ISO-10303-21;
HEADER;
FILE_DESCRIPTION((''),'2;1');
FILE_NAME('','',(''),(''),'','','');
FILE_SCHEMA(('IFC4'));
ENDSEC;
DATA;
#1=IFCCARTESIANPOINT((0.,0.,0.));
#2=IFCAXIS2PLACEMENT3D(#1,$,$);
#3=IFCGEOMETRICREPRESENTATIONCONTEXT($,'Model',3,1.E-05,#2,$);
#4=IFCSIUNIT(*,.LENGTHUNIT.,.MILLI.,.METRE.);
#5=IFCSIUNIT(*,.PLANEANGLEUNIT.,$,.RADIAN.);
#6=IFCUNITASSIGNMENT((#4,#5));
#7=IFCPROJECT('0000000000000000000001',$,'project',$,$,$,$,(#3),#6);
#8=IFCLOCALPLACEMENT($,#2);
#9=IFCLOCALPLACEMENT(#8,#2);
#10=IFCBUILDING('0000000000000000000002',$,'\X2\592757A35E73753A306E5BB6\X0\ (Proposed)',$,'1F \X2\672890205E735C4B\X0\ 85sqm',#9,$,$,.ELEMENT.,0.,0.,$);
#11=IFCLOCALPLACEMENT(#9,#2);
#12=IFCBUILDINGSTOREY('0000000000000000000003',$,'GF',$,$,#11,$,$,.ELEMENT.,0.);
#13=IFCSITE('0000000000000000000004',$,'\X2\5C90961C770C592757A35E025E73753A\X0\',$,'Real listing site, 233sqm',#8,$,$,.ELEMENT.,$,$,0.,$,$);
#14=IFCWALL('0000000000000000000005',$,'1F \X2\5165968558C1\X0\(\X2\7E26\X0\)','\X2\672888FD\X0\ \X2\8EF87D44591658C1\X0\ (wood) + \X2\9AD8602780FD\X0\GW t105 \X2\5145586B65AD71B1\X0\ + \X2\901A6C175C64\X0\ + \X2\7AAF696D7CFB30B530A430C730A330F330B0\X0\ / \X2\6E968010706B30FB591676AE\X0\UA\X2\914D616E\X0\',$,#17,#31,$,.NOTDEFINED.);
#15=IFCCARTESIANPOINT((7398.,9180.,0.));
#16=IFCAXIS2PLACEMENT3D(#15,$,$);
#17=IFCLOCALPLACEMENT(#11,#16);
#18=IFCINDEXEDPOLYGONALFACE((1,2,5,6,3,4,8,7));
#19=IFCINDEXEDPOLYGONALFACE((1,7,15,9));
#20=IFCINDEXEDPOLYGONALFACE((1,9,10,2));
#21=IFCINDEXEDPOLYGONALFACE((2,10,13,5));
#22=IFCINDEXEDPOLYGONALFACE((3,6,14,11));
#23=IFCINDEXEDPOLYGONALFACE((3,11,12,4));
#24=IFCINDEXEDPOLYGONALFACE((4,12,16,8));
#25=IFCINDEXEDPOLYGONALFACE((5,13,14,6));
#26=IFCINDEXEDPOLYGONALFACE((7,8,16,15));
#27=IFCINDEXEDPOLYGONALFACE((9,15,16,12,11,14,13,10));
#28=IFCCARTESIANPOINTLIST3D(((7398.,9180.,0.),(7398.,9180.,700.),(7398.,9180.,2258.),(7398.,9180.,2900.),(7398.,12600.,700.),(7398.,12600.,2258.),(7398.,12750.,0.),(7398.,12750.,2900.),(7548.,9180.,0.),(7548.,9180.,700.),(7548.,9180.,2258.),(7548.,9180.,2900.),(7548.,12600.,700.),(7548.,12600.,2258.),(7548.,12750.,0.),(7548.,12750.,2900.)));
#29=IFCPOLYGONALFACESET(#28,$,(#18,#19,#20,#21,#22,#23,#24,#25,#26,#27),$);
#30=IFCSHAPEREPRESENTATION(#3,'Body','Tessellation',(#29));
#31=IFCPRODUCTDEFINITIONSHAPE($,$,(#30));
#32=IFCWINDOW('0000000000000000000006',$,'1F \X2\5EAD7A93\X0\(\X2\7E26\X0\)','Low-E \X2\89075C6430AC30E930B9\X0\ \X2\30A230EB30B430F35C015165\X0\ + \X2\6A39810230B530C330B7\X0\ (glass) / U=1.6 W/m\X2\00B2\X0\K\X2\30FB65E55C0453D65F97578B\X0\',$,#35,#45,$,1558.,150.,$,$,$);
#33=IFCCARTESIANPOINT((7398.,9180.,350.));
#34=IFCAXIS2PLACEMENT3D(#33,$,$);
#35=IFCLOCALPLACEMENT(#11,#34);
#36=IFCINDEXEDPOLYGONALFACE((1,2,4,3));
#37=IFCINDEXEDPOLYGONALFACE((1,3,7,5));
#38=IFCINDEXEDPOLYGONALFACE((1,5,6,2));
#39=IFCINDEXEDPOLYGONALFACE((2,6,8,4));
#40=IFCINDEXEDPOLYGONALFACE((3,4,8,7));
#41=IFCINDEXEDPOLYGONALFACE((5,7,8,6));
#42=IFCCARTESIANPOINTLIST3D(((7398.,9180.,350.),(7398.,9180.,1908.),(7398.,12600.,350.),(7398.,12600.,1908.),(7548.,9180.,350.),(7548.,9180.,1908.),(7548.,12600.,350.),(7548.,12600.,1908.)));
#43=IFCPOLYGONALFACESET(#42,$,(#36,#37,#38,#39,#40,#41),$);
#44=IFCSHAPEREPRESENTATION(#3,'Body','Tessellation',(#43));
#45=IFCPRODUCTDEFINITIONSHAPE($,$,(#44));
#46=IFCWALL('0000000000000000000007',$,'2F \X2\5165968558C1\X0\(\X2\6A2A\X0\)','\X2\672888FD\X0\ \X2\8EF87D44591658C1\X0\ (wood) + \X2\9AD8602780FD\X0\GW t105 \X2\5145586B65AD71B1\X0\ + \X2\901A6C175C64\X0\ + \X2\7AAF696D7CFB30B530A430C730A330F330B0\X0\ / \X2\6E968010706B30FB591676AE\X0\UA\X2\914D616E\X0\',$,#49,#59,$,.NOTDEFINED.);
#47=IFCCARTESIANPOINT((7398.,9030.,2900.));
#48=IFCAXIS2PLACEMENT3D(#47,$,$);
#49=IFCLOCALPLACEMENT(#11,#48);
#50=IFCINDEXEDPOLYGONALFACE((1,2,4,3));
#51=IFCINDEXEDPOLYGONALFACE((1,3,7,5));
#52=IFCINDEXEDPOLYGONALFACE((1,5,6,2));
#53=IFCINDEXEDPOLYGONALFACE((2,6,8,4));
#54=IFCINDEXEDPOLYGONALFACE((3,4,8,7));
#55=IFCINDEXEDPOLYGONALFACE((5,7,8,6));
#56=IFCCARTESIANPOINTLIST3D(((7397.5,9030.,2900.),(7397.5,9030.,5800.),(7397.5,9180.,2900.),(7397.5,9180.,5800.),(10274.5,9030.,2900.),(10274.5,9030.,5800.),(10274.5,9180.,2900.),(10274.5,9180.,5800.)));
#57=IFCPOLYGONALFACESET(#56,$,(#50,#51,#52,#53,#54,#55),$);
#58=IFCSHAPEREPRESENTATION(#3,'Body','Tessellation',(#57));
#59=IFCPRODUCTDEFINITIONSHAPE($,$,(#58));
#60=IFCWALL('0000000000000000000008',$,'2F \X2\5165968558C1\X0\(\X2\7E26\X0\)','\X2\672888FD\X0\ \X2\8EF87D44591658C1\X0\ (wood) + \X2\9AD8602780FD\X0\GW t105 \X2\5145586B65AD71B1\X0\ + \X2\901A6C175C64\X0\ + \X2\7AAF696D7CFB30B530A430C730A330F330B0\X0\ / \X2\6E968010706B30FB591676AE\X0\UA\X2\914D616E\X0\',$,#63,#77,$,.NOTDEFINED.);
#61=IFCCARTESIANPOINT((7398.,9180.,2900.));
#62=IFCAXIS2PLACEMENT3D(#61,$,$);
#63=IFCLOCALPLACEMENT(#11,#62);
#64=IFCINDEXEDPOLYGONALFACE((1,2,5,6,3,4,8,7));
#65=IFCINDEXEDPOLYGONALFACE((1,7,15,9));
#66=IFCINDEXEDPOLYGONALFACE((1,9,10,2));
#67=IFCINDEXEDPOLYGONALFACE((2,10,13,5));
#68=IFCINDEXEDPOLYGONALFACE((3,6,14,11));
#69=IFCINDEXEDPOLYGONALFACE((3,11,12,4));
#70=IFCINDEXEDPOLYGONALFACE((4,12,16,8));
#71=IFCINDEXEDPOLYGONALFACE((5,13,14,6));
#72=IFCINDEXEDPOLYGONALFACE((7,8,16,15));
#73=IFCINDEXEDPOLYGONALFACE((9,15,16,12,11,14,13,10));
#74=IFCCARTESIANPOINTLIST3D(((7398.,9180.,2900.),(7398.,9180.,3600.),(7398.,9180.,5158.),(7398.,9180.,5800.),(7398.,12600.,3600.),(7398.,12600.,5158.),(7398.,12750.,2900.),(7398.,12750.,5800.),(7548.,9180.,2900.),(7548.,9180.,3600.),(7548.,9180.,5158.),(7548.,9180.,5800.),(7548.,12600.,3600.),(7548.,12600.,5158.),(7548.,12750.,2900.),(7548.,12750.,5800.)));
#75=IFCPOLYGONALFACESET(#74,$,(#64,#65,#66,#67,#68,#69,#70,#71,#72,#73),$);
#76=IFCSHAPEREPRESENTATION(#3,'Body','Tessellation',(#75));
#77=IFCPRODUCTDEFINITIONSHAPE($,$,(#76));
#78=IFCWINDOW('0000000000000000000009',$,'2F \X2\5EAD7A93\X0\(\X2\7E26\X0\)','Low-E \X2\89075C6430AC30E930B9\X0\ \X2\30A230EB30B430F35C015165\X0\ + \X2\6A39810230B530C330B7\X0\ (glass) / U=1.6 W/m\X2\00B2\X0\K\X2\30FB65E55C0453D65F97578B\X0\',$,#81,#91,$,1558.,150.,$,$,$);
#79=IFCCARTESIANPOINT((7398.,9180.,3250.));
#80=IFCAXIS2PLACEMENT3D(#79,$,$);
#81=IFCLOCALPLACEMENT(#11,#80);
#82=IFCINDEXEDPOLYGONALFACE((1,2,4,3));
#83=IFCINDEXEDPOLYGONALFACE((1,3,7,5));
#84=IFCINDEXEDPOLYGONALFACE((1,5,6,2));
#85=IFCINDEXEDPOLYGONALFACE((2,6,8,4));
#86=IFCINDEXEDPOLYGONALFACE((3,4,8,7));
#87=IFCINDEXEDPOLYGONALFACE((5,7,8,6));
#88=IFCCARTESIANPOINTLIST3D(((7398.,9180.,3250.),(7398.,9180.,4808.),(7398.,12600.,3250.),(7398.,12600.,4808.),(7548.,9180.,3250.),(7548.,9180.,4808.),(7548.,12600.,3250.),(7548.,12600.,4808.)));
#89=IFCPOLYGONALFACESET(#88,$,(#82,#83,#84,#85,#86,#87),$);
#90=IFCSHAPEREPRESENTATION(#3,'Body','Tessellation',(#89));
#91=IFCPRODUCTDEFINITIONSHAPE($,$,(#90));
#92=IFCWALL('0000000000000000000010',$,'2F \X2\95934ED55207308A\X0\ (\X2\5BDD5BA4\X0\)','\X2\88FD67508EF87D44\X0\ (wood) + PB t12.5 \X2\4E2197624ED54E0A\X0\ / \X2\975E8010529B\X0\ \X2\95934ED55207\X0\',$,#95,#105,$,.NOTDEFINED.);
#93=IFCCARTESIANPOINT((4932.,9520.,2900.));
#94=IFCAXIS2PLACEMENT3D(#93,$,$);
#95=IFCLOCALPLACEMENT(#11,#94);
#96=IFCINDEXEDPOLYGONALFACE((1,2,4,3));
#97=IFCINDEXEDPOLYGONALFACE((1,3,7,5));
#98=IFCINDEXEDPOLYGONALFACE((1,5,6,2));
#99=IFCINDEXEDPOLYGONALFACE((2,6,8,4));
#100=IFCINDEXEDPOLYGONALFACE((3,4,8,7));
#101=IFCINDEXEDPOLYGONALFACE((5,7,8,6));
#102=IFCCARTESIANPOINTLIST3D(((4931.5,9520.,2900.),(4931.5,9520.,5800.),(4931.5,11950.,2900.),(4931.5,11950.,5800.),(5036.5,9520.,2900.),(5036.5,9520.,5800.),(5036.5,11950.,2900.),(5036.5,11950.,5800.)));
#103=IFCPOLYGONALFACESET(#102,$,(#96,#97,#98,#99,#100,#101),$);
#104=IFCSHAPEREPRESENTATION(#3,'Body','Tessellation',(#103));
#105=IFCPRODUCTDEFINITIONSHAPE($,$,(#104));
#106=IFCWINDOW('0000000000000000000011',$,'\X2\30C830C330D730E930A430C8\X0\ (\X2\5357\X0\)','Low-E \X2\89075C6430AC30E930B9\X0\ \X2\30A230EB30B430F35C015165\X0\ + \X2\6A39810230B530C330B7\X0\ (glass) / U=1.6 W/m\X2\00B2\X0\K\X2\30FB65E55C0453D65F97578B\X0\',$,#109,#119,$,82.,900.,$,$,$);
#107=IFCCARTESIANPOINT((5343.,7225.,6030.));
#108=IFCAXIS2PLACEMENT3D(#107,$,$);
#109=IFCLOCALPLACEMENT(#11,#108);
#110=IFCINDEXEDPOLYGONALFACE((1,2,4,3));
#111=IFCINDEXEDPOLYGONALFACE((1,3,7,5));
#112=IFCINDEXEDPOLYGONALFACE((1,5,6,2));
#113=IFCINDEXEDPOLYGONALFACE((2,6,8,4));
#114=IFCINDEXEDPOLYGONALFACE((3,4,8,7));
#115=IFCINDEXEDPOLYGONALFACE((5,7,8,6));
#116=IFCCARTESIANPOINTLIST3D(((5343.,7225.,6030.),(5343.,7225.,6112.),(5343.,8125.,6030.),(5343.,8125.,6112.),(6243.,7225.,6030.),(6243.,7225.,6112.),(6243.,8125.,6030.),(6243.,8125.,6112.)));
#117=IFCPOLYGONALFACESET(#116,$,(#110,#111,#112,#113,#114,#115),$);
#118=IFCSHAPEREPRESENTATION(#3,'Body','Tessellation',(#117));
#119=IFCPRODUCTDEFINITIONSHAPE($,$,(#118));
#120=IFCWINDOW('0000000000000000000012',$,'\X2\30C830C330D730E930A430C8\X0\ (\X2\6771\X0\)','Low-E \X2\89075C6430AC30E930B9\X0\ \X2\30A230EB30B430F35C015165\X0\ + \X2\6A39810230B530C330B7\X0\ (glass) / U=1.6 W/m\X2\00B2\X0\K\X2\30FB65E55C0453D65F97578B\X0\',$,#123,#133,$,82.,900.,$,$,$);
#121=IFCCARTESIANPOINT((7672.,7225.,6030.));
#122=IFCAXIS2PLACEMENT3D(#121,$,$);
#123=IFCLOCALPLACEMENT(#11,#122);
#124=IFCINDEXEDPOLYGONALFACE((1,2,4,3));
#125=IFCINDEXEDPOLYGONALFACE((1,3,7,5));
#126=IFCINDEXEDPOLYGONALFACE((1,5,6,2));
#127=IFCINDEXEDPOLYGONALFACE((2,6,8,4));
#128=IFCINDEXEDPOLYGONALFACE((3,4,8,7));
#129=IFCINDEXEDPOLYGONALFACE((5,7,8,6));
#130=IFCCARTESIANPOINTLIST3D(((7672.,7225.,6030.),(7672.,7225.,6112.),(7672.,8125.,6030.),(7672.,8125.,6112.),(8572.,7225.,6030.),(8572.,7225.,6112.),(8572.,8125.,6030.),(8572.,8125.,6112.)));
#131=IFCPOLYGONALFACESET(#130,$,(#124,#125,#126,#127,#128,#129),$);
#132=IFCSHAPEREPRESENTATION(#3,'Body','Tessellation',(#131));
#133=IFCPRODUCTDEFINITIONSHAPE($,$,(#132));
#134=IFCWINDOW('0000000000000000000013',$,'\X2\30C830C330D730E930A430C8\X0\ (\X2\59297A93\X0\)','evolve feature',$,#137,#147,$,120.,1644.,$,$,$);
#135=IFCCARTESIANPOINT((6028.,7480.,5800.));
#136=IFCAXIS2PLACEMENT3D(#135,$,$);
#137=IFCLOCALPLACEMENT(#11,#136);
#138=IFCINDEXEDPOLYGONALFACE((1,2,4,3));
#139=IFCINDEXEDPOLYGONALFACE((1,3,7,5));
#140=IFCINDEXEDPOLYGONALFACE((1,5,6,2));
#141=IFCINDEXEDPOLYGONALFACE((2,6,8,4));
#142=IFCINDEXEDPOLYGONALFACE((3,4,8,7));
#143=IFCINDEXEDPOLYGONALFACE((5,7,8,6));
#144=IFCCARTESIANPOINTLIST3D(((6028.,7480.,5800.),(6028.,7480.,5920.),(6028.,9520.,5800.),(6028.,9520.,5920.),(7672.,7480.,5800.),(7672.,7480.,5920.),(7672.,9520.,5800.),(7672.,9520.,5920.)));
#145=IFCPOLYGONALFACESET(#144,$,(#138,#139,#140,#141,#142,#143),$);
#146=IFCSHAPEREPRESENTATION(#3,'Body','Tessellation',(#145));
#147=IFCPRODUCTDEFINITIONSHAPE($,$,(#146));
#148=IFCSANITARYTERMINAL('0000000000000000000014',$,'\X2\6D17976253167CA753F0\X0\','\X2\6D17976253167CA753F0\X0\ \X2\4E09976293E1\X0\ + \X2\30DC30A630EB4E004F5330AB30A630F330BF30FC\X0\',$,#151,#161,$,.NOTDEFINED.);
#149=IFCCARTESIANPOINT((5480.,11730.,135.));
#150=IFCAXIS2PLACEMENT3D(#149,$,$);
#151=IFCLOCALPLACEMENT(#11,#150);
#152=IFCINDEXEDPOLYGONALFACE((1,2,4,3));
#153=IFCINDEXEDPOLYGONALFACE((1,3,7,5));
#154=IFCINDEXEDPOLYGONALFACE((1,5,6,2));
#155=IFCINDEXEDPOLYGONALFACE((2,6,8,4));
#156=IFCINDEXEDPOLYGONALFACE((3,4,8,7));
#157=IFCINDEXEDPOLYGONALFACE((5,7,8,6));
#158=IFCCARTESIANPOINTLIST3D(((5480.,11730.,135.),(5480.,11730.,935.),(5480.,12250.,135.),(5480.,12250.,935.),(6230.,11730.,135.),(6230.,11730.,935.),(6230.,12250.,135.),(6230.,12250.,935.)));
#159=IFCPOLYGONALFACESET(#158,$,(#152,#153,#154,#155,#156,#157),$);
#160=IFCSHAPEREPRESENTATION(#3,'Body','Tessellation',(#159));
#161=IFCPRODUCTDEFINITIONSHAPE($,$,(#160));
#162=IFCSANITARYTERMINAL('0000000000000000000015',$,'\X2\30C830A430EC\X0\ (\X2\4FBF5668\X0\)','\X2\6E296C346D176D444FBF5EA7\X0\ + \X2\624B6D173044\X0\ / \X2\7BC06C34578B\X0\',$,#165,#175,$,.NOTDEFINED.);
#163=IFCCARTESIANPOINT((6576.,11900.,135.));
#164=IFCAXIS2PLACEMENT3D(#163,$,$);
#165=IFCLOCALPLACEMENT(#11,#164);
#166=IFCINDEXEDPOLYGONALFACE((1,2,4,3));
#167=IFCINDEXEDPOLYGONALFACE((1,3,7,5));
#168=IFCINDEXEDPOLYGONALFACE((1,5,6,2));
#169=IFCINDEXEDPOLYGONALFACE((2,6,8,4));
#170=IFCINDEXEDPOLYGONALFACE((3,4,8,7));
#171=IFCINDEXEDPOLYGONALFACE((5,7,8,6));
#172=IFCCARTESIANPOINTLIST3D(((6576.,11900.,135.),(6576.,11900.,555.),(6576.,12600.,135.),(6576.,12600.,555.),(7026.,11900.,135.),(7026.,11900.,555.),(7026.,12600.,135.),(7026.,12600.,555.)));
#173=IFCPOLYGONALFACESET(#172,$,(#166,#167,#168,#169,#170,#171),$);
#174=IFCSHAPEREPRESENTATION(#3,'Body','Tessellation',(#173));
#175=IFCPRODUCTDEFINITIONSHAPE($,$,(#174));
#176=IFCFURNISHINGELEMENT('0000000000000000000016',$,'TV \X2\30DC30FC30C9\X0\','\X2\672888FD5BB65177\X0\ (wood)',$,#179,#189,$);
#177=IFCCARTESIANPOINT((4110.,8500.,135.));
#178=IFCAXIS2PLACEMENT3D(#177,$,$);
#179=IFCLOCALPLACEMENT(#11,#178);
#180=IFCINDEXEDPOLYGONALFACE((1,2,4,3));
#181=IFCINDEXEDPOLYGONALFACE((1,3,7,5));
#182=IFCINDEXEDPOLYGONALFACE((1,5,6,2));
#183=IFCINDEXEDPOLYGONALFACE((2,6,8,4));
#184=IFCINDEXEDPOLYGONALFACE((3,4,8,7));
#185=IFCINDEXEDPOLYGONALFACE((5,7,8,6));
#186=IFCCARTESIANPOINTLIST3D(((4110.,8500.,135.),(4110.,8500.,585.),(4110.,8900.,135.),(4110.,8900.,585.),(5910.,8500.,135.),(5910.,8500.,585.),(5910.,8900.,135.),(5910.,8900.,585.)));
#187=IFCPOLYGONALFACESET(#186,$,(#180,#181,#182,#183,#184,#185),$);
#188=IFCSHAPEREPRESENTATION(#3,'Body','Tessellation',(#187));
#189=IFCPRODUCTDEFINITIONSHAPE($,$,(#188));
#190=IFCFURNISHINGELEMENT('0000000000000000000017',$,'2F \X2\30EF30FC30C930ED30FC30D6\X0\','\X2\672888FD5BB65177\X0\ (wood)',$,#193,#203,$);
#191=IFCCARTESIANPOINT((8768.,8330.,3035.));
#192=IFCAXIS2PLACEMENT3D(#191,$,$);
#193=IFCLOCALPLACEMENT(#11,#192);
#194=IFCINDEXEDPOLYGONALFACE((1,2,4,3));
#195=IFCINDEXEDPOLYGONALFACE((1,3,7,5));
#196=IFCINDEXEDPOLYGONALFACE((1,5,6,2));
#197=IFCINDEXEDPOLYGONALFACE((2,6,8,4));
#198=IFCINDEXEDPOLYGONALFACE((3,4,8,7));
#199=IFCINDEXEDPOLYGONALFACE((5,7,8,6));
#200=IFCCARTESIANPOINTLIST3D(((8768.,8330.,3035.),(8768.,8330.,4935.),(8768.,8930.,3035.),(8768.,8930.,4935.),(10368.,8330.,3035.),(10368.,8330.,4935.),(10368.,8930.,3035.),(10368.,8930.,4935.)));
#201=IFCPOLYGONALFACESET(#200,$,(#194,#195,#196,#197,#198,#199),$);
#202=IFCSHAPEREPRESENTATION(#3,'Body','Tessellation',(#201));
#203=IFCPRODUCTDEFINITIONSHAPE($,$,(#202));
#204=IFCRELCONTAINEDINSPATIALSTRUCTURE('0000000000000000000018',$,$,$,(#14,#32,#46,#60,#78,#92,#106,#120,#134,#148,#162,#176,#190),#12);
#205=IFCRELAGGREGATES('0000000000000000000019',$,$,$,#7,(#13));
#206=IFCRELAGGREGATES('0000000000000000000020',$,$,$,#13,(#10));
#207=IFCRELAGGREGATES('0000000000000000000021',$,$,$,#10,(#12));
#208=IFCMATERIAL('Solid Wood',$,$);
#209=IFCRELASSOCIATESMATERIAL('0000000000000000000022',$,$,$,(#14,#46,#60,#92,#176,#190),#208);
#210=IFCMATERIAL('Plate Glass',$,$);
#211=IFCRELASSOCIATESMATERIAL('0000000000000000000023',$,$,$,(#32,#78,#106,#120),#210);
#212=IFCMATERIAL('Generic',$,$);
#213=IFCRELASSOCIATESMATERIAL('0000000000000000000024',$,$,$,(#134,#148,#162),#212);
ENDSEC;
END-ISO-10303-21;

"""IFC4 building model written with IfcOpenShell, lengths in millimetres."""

from ifc_helpers import new_model, si_unit, frame, frame_2d, origin, place, context, project, spatial, rectangle, extrude, material, element, fill, save


model = new_model("IFC4")

# Units and contexts
model_context = context("Model", 3, precision=1e-05, world=origin())
ifc_project = project(units=[si_unit("LENGTHUNIT", "METRE", prefix="MILLI"), si_unit("PLANEANGLEUNIT", "RADIAN")], contexts=[model_context])

# Site, building, storey
site_placement = place(None, origin())
site = spatial("IfcSite", under=ifc_project, at=site_placement, Name="岐阜県大垣市平町", ObjectType="Real listing site, 233sqm", CompositionType="ELEMENT", RefElevation=0.0)
building_placement = place(site_placement, origin())
building = spatial("IfcBuilding", under=site, at=building_placement, Name="大垣平町の家 (Proposed)", ObjectType="1F 木造平屋 85sqm", CompositionType="ELEMENT", ElevationOfRefHeight=0.0, ElevationOfTerrain=0.0)
storey_placement = place(building_placement, origin())
storey = spatial("IfcBuildingStorey", under=building, at=storey_placement, Name="GF", CompositionType="ELEMENT", Elevation=0.0)

# Shared definitions
ifc_material_1 = material(Name="Solid Wood")

# Wall, opening, window
wall_1_placement = place(storey_placement, frame((7398.0, 9180.0, 0.0)))
wall_1 = element("IfcWall", 1, at=wall_1_placement, inside=storey, material=ifc_material_1, Name="1F 入隅壁(縦)", Description="木製 軸組外壁 (wood) + 高性能GW t105 充填断熱 + 通気層 + 窯業系サイディング / 準耐火・外皮UA配慮", PredefinedType="NOTDEFINED", context=model_context, shape_type="SweptSolid", body=[
    extrude(rectangle(XDim=150.0, YDim=3570.0, at=frame_2d((75.0, 1785.0))), frame((7398.0, 9180.0, 0.0)), (0.0, 0.0, 1.0), 2900.0),
])
opening_1_placement = place(storey_placement, frame((7398.0, 9180.0, 350.0)))
opening_1 = element("IfcOpeningElement", 2, at=opening_1_placement, cuts=wall_1, PredefinedType="NOTDEFINED", context=model_context, shape_type="SweptSolid", body=[
    extrude(rectangle(XDim=150.0, YDim=3420.0, at=frame_2d((75.0, 1710.0))), frame((7398.0, 9180.0, 350.0)), (0.0, 0.0, 1.0), 1558.0),
])
ifc_material_2 = material(Name="Plate Glass")
window_1_placement = place(storey_placement, frame((7398.0, 9180.0, 350.0)))
window_1 = element("IfcWindow", 3, at=window_1_placement, inside=storey, material=ifc_material_2, Name="1F 庭窓(縦)", Description="Low-E 複層ガラス アルゴン封入 + 樹脂サッシ (glass) / U=1.6 W/m²K・日射取得型", OverallHeight=1558.0, OverallWidth=150.0, context=model_context, shape_type="SweptSolid", body=[
    extrude(rectangle(XDim=150.0, YDim=3420.0, at=frame_2d((75.0, 1710.0))), frame((7398.0, 9180.0, 350.0)), (0.0, 0.0, 1.0), 1558.0),
])
fill(opening_1, window_1)

# Wall
wall_2_placement = place(storey_placement, frame((7398.0, 9030.0, 2900.0)))
element("IfcWall", 4, at=wall_2_placement, inside=storey, material=ifc_material_1, Name="2F 入隅壁(横)", Description="木製 軸組外壁 (wood) + 高性能GW t105 充填断熱 + 通気層 + 窯業系サイディング / 準耐火・外皮UA配慮", PredefinedType="NOTDEFINED", context=model_context, shape_type="SweptSolid", body=[
    extrude(rectangle(XDim=2877.0, YDim=150.0, at=frame_2d((1438.0, 75.0))), frame((7398.0, 9030.0, 2900.0)), (0.0, 0.0, 1.0), 2900.0),
])

# Wall, opening, window
wall_3_placement = place(storey_placement, frame((7398.0, 9180.0, 2900.0)))
wall_3 = element("IfcWall", 5, at=wall_3_placement, inside=storey, material=ifc_material_1, Name="2F 入隅壁(縦)", Description="木製 軸組外壁 (wood) + 高性能GW t105 充填断熱 + 通気層 + 窯業系サイディング / 準耐火・外皮UA配慮", PredefinedType="NOTDEFINED", context=model_context, shape_type="SweptSolid", body=[
    extrude(rectangle(XDim=150.0, YDim=3570.0, at=frame_2d((75.0, 1785.0))), frame((7398.0, 9180.0, 2900.0)), (0.0, 0.0, 1.0), 2900.0),
])
opening_2_placement = place(storey_placement, frame((7398.0, 9180.0, 3250.0)))
opening_2 = element("IfcOpeningElement", 6, at=opening_2_placement, cuts=wall_3, PredefinedType="NOTDEFINED", context=model_context, shape_type="SweptSolid", body=[
    extrude(rectangle(XDim=150.0, YDim=3420.0, at=frame_2d((75.0, 1710.0))), frame((7398.0, 9180.0, 3250.0)), (0.0, 0.0, 1.0), 1558.0),
])
window_2_placement = place(storey_placement, frame((7398.0, 9180.0, 3250.0)))
window_2 = element("IfcWindow", 7, at=window_2_placement, inside=storey, material=ifc_material_2, Name="2F 庭窓(縦)", Description="Low-E 複層ガラス アルゴン封入 + 樹脂サッシ (glass) / U=1.6 W/m²K・日射取得型", OverallHeight=1558.0, OverallWidth=150.0, context=model_context, shape_type="SweptSolid", body=[
    extrude(rectangle(XDim=150.0, YDim=3420.0, at=frame_2d((75.0, 1710.0))), frame((7398.0, 9180.0, 3250.0)), (0.0, 0.0, 1.0), 1558.0),
])
fill(opening_2, window_2)

# Wall
wall_4_placement = place(storey_placement, frame((4932.0, 9520.0, 2900.0)))
element("IfcWall", 8, at=wall_4_placement, inside=storey, material=ifc_material_1, Name="2F 間仕切り (寝室)", Description="製材軸組 (wood) + PB t12.5 両面仕上 / 非耐力 間仕切", PredefinedType="NOTDEFINED", context=model_context, shape_type="SweptSolid", body=[
    extrude(rectangle(XDim=105.0, YDim=2430.0, at=frame_2d((52.0, 1215.0))), frame((4932.0, 9520.0, 2900.0)), (0.0, 0.0, 1.0), 2900.0),
])

# Windows
window_3_placement = place(storey_placement, frame((5343.0, 7225.0, 6030.0)))
element("IfcWindow", 9, at=window_3_placement, inside=storey, material=ifc_material_2, Name="トップライト (南)", Description="Low-E 複層ガラス アルゴン封入 + 樹脂サッシ (glass) / U=1.6 W/m²K・日射取得型", OverallHeight=82.0, OverallWidth=900.0, context=model_context, shape_type="SweptSolid", body=[
    extrude(rectangle(XDim=900.0, YDim=900.0, at=frame_2d((450.0, 450.0))), frame((5343.0, 7225.0, 6030.0)), (0.0, 0.0, 1.0), 82.0),
])
window_4_placement = place(storey_placement, frame((7672.0, 7225.0, 6030.0)))
element("IfcWindow", 10, at=window_4_placement, inside=storey, material=ifc_material_2, Name="トップライト (東)", Description="Low-E 複層ガラス アルゴン封入 + 樹脂サッシ (glass) / U=1.6 W/m²K・日射取得型", OverallHeight=82.0, OverallWidth=900.0, context=model_context, shape_type="SweptSolid", body=[
    extrude(rectangle(XDim=900.0, YDim=900.0, at=frame_2d((450.0, 450.0))), frame((7672.0, 7225.0, 6030.0)), (0.0, 0.0, 1.0), 82.0),
])
ifc_material_3 = material(Name="Generic")
window_5_placement = place(storey_placement, frame((6028.0, 7480.0, 5800.0)))
element("IfcWindow", 11, at=window_5_placement, inside=storey, material=ifc_material_3, Name="トップライト (天窓)", Description="evolve feature", OverallHeight=120.0, OverallWidth=1644.0, context=model_context, shape_type="SweptSolid", body=[
    extrude(rectangle(XDim=1644.0, YDim=2040.0, at=frame_2d((822.0, 1020.0))), frame((6028.0, 7480.0, 5800.0)), (0.0, 0.0, 1.0), 120.0),
])

# Sanitary terminals
sanitary_terminal_1_placement = place(storey_placement, frame((5480.0, 11730.0, 135.0)))
element("IfcSanitaryTerminal", 12, at=sanitary_terminal_1_placement, inside=storey, material=ifc_material_3, Name="洗面化粧台", Description="洗面化粧台 三面鏡 + ボウル一体カウンター", PredefinedType="NOTDEFINED", context=model_context, shape_type="SweptSolid", body=[
    extrude(rectangle(XDim=750.0, YDim=520.0, at=frame_2d((375.0, 260.0))), frame((5480.0, 11730.0, 135.0)), (0.0, 0.0, 1.0), 800.0),
])
sanitary_terminal_2_placement = place(storey_placement, frame((6576.0, 11900.0, 135.0)))
element("IfcSanitaryTerminal", 13, at=sanitary_terminal_2_placement, inside=storey, material=ifc_material_3, Name="トイレ (便器)", Description="温水洗浄便座 + 手洗い / 節水型", PredefinedType="NOTDEFINED", context=model_context, shape_type="SweptSolid", body=[
    extrude(rectangle(XDim=450.0, YDim=700.0, at=frame_2d((225.0, 350.0))), frame((6576.0, 11900.0, 135.0)), (0.0, 0.0, 1.0), 420.0),
])

# Furnishing elements
furnishing_1_placement = place(storey_placement, frame((4110.0, 8500.0, 135.0)))
element("IfcFurnishingElement", 14, at=furnishing_1_placement, inside=storey, material=ifc_material_1, Name="TV ボード", Description="木製家具 (wood)", context=model_context, shape_type="SweptSolid", body=[
    extrude(rectangle(XDim=1800.0, YDim=400.0, at=frame_2d((900.0, 200.0))), frame((4110.0, 8500.0, 135.0)), (0.0, 0.0, 1.0), 450.0),
])
furnishing_2_placement = place(storey_placement, frame((8768.0, 8330.0, 3035.0)))
element("IfcFurnishingElement", 15, at=furnishing_2_placement, inside=storey, material=ifc_material_1, Name="2F ワードローブ", Description="木製家具 (wood)", context=model_context, shape_type="SweptSolid", body=[
    extrude(rectangle(XDim=1600.0, YDim=600.0, at=frame_2d((800.0, 300.0))), frame((8768.0, 8330.0, 3035.0)), (0.0, 0.0, 1.0), 1900.0),
])

save(model, "model.ifc")
